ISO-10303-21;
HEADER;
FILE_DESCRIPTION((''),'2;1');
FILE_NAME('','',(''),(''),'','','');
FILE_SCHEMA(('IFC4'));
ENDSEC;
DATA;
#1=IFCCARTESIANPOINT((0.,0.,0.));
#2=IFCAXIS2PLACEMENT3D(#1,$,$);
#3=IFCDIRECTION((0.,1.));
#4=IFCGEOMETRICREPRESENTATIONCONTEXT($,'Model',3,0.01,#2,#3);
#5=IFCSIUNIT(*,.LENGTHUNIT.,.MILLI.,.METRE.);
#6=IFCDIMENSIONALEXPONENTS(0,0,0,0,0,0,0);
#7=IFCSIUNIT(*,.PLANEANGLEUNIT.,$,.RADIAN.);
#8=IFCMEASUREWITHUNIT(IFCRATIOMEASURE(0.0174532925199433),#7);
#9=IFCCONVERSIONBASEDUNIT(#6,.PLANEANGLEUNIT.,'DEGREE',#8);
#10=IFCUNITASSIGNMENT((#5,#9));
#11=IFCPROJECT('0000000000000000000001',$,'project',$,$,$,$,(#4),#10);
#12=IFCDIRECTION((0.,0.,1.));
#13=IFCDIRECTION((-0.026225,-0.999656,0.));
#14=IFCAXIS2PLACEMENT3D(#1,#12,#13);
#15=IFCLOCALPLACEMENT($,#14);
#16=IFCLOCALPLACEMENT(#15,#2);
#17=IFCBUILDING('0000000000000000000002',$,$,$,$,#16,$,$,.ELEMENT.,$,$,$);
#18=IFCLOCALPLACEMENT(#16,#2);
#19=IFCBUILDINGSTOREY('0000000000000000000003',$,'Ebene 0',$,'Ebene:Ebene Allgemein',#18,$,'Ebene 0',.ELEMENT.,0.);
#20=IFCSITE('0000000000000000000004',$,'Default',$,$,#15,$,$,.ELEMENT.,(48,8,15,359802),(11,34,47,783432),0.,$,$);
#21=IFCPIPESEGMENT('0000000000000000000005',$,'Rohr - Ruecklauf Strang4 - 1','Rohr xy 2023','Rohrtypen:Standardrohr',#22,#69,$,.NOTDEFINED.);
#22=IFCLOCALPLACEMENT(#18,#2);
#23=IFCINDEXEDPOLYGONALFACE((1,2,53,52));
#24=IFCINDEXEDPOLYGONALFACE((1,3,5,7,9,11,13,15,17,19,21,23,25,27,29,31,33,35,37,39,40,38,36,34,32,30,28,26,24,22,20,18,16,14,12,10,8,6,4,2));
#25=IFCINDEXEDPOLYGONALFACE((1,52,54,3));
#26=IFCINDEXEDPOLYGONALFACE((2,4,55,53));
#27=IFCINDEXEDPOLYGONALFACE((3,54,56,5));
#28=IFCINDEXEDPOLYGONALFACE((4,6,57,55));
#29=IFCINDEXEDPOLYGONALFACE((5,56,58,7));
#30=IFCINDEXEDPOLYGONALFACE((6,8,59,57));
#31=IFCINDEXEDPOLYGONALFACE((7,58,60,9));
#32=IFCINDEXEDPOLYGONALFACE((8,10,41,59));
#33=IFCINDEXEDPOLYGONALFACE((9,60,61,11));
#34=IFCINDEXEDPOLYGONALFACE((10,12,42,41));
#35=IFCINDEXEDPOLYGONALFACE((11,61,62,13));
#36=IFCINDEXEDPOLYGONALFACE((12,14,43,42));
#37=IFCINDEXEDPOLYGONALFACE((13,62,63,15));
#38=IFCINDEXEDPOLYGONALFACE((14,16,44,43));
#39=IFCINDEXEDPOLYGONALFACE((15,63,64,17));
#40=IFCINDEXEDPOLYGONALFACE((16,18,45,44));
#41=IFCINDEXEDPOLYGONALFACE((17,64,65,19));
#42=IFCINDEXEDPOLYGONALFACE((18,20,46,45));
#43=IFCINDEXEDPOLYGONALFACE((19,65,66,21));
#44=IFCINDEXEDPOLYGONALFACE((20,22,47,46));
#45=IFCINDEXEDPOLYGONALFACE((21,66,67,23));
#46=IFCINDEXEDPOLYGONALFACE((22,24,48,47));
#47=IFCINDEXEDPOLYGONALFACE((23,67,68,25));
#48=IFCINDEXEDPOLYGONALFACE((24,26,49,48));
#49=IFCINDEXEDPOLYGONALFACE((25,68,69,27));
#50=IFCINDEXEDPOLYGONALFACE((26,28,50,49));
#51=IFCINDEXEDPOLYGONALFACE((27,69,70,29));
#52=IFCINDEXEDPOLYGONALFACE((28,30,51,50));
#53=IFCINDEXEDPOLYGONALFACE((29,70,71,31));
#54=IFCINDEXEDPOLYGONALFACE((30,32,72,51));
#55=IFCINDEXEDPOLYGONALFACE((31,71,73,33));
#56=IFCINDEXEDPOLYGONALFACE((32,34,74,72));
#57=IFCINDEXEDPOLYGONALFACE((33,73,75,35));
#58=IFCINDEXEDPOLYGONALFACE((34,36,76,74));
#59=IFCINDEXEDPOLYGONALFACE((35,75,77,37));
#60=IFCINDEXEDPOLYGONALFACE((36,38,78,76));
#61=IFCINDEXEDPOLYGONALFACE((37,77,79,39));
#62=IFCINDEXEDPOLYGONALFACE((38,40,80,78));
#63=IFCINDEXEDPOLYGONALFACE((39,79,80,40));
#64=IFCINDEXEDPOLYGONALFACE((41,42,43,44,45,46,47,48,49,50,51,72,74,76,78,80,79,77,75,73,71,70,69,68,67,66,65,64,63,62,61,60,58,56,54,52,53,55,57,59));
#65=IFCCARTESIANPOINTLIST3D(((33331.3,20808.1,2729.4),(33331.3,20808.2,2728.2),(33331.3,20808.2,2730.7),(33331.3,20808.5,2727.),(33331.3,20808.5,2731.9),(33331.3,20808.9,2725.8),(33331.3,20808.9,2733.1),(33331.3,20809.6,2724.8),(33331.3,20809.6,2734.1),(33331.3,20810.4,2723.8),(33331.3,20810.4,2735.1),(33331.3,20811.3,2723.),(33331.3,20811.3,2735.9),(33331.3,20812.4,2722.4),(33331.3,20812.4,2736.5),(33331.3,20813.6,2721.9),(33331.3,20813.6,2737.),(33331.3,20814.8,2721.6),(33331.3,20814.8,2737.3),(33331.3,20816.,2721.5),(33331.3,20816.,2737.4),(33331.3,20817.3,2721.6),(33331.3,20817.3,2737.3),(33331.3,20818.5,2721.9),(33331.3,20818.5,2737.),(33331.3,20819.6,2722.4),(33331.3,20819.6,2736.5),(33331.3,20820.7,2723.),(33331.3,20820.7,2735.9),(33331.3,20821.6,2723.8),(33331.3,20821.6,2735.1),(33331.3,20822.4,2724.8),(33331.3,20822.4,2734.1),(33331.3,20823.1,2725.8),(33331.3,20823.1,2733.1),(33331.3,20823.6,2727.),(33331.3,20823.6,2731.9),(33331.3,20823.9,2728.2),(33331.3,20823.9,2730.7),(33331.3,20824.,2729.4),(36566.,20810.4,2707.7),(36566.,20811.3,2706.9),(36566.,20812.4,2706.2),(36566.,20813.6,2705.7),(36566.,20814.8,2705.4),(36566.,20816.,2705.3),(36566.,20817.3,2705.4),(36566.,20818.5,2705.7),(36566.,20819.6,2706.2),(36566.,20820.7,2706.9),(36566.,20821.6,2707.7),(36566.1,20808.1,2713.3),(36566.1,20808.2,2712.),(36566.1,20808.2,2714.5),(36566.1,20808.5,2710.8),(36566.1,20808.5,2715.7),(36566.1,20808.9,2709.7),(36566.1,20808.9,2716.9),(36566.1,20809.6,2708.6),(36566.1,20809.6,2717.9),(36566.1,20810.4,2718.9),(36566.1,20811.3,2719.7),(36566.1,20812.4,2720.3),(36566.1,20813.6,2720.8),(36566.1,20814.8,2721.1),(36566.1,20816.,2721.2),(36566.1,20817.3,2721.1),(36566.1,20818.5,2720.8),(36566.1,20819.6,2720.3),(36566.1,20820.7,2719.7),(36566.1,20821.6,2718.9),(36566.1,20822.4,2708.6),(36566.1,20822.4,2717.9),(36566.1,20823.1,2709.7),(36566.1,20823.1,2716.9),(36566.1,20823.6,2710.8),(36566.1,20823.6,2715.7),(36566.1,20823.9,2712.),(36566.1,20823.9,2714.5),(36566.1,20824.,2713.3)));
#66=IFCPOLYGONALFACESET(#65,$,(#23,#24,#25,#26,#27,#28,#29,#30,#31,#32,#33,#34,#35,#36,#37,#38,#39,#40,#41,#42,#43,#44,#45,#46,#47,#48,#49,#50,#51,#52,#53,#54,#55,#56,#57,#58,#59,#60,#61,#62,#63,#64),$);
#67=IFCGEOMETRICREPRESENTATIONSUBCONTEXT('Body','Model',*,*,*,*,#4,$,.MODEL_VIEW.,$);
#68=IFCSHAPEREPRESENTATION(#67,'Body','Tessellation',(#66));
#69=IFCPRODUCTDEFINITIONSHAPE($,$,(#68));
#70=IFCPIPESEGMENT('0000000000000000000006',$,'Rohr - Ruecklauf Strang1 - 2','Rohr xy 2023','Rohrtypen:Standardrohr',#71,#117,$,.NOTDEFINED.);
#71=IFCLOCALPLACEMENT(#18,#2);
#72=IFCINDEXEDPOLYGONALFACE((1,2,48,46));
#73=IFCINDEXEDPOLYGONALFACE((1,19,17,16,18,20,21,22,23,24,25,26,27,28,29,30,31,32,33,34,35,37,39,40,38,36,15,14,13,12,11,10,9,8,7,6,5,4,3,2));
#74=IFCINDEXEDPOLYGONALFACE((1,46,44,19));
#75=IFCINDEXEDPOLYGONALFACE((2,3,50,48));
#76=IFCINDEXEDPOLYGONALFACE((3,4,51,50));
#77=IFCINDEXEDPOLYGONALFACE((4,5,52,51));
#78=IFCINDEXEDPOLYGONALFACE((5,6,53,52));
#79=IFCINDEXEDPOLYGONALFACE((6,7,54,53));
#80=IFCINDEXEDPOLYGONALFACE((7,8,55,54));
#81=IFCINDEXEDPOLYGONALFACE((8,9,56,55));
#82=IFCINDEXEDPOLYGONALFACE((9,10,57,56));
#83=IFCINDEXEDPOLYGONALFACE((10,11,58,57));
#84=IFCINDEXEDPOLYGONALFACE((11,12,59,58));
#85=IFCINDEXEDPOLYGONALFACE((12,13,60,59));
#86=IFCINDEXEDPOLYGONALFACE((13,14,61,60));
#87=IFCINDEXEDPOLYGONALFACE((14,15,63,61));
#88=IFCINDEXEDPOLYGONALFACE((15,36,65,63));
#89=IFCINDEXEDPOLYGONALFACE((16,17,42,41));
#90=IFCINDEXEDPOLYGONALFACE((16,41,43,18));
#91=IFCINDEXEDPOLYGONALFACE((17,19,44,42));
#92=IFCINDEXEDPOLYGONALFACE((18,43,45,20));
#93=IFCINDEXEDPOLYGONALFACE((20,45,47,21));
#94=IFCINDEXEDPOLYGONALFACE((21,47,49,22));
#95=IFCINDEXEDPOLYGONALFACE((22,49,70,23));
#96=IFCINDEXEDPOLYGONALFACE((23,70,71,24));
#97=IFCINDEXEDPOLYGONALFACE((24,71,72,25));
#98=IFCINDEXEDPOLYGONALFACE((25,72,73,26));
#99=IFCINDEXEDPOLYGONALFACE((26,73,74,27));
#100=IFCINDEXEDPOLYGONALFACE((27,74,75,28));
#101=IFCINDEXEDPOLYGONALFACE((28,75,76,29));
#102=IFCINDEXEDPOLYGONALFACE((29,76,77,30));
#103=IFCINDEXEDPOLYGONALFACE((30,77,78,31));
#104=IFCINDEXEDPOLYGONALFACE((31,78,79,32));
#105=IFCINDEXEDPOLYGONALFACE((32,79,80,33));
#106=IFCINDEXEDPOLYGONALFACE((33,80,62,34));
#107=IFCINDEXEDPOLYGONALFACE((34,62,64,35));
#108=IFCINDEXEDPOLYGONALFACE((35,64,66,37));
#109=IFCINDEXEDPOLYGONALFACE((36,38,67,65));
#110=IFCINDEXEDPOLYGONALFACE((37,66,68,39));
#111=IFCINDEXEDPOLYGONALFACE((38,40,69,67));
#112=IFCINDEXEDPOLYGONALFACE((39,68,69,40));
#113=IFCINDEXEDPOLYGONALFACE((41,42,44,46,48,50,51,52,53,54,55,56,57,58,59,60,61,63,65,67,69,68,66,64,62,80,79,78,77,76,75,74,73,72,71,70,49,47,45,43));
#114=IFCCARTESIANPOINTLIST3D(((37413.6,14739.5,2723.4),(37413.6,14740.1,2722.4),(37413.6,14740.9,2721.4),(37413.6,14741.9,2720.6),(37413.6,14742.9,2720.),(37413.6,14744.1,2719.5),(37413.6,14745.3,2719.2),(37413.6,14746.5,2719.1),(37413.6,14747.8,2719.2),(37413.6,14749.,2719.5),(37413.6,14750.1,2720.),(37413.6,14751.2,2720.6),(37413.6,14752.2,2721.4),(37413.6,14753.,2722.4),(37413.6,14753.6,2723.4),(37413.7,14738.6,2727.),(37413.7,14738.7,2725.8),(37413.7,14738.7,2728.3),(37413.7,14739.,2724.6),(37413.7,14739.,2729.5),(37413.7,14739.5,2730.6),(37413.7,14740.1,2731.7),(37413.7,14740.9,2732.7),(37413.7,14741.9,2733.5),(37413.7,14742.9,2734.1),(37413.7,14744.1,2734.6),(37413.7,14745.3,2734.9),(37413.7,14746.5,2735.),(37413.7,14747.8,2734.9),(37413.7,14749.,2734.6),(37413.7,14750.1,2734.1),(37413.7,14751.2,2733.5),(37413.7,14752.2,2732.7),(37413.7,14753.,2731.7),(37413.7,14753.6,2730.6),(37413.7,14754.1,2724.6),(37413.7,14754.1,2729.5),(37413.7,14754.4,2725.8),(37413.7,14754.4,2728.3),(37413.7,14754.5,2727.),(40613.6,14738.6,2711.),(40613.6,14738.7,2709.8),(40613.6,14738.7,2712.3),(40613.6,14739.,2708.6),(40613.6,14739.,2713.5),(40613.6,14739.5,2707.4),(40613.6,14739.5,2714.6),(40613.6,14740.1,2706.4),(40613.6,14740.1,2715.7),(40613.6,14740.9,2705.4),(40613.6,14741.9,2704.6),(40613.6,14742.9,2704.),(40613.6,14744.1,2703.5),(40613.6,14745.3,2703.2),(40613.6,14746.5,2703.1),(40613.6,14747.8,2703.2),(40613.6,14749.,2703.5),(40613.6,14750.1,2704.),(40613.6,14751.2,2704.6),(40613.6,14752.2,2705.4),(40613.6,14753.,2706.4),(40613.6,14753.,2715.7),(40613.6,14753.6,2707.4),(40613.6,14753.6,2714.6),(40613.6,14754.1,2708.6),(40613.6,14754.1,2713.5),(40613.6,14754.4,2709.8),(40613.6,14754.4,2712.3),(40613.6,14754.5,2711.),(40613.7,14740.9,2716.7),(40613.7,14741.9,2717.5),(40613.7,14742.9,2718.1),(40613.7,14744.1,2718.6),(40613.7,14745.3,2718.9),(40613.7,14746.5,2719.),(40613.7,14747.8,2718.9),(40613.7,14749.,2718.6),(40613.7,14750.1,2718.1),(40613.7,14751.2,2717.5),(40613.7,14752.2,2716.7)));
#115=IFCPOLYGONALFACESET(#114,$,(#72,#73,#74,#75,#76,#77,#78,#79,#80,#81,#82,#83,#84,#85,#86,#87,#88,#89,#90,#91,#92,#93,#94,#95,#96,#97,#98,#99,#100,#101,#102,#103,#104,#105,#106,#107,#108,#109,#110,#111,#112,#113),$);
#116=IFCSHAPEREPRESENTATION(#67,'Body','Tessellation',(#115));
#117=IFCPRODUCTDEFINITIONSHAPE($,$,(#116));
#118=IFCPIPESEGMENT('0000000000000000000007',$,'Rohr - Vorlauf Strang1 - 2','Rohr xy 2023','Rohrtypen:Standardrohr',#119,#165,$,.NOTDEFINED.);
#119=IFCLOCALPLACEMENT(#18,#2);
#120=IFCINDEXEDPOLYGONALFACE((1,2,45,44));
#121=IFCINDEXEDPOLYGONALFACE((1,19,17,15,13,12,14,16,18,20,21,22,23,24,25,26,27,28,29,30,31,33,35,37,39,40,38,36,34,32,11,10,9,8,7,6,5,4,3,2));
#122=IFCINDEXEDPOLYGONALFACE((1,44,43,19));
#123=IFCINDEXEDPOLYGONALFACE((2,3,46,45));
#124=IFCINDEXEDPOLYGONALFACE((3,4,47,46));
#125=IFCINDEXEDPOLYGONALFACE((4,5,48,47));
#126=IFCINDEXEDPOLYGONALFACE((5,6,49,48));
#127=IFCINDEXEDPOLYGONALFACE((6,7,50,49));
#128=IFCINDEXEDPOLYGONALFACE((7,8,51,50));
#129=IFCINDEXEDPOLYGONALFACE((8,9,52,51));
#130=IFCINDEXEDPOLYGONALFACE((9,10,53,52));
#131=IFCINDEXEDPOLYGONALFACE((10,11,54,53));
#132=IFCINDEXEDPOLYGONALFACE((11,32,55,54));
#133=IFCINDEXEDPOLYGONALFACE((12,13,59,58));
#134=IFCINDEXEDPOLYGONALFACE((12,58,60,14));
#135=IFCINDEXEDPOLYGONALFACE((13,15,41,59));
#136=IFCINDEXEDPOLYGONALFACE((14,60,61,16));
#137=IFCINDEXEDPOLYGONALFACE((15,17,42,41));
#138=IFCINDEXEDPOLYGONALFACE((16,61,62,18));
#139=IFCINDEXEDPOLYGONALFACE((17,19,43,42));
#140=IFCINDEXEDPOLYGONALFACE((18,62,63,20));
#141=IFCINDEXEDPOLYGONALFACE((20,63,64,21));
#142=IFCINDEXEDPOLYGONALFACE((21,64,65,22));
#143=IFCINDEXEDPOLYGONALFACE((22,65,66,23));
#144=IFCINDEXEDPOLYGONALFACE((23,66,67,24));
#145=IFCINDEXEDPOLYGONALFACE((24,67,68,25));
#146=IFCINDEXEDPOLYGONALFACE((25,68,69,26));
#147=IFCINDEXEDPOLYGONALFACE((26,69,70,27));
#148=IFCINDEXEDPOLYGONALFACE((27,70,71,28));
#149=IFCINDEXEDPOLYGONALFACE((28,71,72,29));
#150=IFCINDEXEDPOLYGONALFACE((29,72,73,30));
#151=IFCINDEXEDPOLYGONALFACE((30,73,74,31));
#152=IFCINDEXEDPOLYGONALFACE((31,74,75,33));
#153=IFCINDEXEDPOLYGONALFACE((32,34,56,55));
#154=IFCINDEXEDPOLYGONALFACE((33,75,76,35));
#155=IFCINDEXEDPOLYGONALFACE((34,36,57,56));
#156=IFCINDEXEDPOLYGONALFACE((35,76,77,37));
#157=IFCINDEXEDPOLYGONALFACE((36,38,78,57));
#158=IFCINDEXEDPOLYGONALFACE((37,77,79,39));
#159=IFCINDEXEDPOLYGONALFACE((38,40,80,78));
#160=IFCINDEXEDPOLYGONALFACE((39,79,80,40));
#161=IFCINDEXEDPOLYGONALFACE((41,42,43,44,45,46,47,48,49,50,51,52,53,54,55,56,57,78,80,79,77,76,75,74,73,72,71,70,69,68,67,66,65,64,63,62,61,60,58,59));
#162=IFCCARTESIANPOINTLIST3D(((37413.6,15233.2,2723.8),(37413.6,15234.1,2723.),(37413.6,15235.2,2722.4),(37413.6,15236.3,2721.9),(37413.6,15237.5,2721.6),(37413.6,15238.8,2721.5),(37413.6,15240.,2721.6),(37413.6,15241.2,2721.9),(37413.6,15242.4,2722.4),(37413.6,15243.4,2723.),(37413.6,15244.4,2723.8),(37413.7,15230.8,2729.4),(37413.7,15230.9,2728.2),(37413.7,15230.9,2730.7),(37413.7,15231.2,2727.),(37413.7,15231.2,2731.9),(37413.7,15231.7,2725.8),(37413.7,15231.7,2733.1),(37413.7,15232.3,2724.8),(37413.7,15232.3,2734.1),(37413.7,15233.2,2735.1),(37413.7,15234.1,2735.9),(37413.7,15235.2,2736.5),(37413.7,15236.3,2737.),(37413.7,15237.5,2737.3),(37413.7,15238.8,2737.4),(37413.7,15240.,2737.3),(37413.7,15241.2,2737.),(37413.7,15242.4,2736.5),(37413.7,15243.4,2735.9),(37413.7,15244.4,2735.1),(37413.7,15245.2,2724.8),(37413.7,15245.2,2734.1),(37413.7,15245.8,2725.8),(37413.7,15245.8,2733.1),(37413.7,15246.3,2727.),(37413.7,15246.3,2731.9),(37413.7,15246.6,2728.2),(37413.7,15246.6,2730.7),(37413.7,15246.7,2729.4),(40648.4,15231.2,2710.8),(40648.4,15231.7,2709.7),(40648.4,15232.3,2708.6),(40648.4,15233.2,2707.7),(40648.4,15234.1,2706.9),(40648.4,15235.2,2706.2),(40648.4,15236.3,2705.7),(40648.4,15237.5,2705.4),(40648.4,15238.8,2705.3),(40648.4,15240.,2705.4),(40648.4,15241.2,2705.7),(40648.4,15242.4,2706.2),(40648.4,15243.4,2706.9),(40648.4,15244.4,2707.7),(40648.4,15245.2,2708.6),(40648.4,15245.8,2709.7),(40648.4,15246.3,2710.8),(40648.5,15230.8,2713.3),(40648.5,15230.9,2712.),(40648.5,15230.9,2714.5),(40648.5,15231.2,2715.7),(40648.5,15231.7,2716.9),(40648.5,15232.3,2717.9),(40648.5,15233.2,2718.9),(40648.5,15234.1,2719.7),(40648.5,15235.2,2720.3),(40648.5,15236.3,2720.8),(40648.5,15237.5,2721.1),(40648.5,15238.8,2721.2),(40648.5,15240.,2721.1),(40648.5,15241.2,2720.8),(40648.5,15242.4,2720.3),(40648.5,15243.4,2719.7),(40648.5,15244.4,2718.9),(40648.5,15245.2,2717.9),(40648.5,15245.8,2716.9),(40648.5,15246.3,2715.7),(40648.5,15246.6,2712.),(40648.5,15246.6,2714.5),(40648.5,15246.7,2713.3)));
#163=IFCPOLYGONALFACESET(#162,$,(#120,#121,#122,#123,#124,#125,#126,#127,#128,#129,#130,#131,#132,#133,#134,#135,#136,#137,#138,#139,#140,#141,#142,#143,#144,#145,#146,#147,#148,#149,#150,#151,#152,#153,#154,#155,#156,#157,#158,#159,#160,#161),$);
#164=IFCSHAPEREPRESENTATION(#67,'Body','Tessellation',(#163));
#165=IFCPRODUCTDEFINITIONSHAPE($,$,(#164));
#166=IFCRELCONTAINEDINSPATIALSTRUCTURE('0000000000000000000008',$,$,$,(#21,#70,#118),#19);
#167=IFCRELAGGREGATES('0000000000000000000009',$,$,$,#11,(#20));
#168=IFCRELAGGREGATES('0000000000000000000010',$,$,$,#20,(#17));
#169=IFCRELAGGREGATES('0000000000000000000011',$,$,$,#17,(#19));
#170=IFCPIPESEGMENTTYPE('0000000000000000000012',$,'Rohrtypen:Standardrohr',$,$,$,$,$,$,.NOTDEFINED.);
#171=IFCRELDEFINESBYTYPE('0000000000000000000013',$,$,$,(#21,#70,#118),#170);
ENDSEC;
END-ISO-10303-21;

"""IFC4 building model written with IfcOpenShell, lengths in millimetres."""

from ifc_helpers import new_model, entity, si_unit, converted_unit, direction, frame, origin, place, context, subcontext, project, spatial, indexed_curve, outline, extrude, type_object, element, save


model = new_model("IFC4")

# Units and contexts
model_context = context("Model", 3, precision=0.01, world=origin(), true_north=direction((0.0, 1.0)))
body_context = subcontext(model_context, "Body", "Model", "MODEL_VIEW")
ifc_project = project(units=[si_unit("LENGTHUNIT", "METRE", prefix="MILLI"), converted_unit("PLANEANGLEUNIT", "DEGREE", entity("IfcRatioMeasure", 0.0174532925199433), si_unit("PLANEANGLEUNIT", "RADIAN"), dimensions=[0, 0, 0, 0, 0, 0, 0])], contexts=[model_context])

# Site, building, storey
site_placement = place(None, frame((0.0, 0.0, 0.0), z_axis=(0.0, 0.0, 1.0), x_axis=(-0.026225, -0.999656, 0.0)))
site = spatial("IfcSite", under=ifc_project, at=site_placement, Name="Default", CompositionType="ELEMENT", RefLatitude=(48, 8, 15, 359802), RefLongitude=(11, 34, 47, 783432), RefElevation=0.0)
building_placement = place(site_placement, origin())
building = spatial("IfcBuilding", under=site, at=building_placement, CompositionType="ELEMENT")
storey_placement = place(building_placement, origin())
storey = spatial("IfcBuildingStorey", under=building, at=storey_placement, Name="Ebene 0", ObjectType="Ebene:Ebene Allgemein", LongName="Ebene 0", CompositionType="ELEMENT", Elevation=0.0)

# Pipe segments
pipe_segment_type = type_object("IfcPipeSegmentType", Name="Rohrtypen:Standardrohr", PredefinedType="NOTDEFINED")
pipe_segment_1_placement = place(storey_placement, origin())
element("IfcPipeSegment", 1, at=pipe_segment_1_placement, inside=storey, type_object=pipe_segment_type, Name="Rohr - Ruecklauf Strang4 - 1", Description="Rohr xy 2023", ObjectType="Rohrtypen:Standardrohr", PredefinedType="NOTDEFINED", context=body_context, shape_type="SweptSolid", body=[
    extrude(outline(indexed_curve([(7.9, 0.0), (7.8, 1.2), (7.6, 2.5), (7.1, 3.6), (6.4, 4.7), (5.6, 5.6), (4.7, 6.4), (3.6, 7.1), (2.5, 7.6), (1.2, 7.8), (0.0, 7.9), (-1.2, 7.8), (-2.5, 7.6), (-3.6, 7.1), (-4.7, 6.4), (-5.6, 5.6), (-6.4, 4.7), (-7.1, 3.6), (-7.6, 2.5), (-7.8, 1.2), (-7.9, 0.0), (-7.8, -1.2), (-7.6, -2.5), (-7.1, -3.6), (-6.4, -4.7), (-5.6, -5.6), (-4.7, -6.4), (-3.6, -7.1), (-2.5, -7.6), (-1.2, -7.8), (0.0, -7.9), (1.2, -7.8), (2.5, -7.6), (3.6, -7.1), (4.7, -6.4), (5.6, -5.6), (6.4, -4.7), (7.1, -3.6), (7.6, -2.5), (7.8, -1.2), (7.9, 0.0)], self_intersect=False)), frame((36566.1, 20816.0, 2713.3), z_axis=(-0.999988, 0.0, 0.005), x_axis=(0.0, 1.0, 0.0)), (0.0, 0.0, 1.0), 3234.8),
])
pipe_segment_2_placement = place(storey_placement, origin())
element("IfcPipeSegment", 2, at=pipe_segment_2_placement, inside=storey, type_object=pipe_segment_type, Name="Rohr - Ruecklauf Strang1 - 2", Description="Rohr xy 2023", ObjectType="Rohrtypen:Standardrohr", PredefinedType="NOTDEFINED", context=body_context, shape_type="SweptSolid", body=[
    extrude(outline(indexed_curve([(7.9, 0.0), (7.8, 1.2), (7.6, 2.5), (7.1, 3.6), (6.4, 4.7), (5.6, 5.6), (4.7, 6.4), (3.6, 7.1), (2.5, 7.6), (1.2, 7.8), (0.0, 7.9), (-1.2, 7.8), (-2.5, 7.6), (-3.6, 7.1), (-4.7, 6.4), (-5.6, 5.6), (-6.4, 4.7), (-7.1, 3.6), (-7.6, 2.5), (-7.8, 1.2), (-7.9, 0.0), (-7.8, -1.2), (-7.6, -2.5), (-7.1, -3.6), (-6.4, -4.7), (-5.6, -5.6), (-4.7, -6.4), (-3.6, -7.1), (-2.5, -7.6), (-1.2, -7.8), (0.0, -7.9), (1.2, -7.8), (2.5, -7.6), (3.6, -7.1), (4.7, -6.4), (5.6, -5.6), (6.4, -4.7), (7.1, -3.6), (7.6, -2.5), (7.8, -1.2), (7.9, 0.0)], self_intersect=False)), frame((40613.6, 14746.5, 2711.0), z_axis=(-0.999988, 0.0, 0.005), x_axis=(0.0, 1.0, 0.0)), (0.0, 0.0, 1.0), 3200.0),
])
pipe_segment_3_placement = place(storey_placement, origin())
element("IfcPipeSegment", 3, at=pipe_segment_3_placement, inside=storey, type_object=pipe_segment_type, Name="Rohr - Vorlauf Strang1 - 2", Description="Rohr xy 2023", ObjectType="Rohrtypen:Standardrohr", PredefinedType="NOTDEFINED", context=body_context, shape_type="SweptSolid", body=[
    extrude(outline(indexed_curve([(7.9, 0.0), (7.8, 1.2), (7.6, 2.5), (7.1, 3.6), (6.4, 4.7), (5.6, 5.6), (4.7, 6.4), (3.6, 7.1), (2.5, 7.6), (1.2, 7.8), (0.0, 7.9), (-1.2, 7.8), (-2.5, 7.6), (-3.6, 7.1), (-4.7, 6.4), (-5.6, 5.6), (-6.4, 4.7), (-7.1, 3.6), (-7.6, 2.5), (-7.8, 1.2), (-7.9, 0.0), (-7.8, -1.2), (-7.6, -2.5), (-7.1, -3.6), (-6.4, -4.7), (-5.6, -5.6), (-4.7, -6.4), (-3.6, -7.1), (-2.5, -7.6), (-1.2, -7.8), (0.0, -7.9), (1.2, -7.8), (2.5, -7.6), (3.6, -7.1), (4.7, -6.4), (5.6, -5.6), (6.4, -4.7), (7.1, -3.6), (7.6, -2.5), (7.8, -1.2), (7.9, 0.0)], self_intersect=False)), frame((40648.5, 15238.8, 2713.3), z_axis=(-0.999988, 0.0, 0.005), x_axis=(0.0, 1.0, 0.0)), (0.0, 0.0, 1.0), 3234.8),
])

save(model, "model.ifc")
